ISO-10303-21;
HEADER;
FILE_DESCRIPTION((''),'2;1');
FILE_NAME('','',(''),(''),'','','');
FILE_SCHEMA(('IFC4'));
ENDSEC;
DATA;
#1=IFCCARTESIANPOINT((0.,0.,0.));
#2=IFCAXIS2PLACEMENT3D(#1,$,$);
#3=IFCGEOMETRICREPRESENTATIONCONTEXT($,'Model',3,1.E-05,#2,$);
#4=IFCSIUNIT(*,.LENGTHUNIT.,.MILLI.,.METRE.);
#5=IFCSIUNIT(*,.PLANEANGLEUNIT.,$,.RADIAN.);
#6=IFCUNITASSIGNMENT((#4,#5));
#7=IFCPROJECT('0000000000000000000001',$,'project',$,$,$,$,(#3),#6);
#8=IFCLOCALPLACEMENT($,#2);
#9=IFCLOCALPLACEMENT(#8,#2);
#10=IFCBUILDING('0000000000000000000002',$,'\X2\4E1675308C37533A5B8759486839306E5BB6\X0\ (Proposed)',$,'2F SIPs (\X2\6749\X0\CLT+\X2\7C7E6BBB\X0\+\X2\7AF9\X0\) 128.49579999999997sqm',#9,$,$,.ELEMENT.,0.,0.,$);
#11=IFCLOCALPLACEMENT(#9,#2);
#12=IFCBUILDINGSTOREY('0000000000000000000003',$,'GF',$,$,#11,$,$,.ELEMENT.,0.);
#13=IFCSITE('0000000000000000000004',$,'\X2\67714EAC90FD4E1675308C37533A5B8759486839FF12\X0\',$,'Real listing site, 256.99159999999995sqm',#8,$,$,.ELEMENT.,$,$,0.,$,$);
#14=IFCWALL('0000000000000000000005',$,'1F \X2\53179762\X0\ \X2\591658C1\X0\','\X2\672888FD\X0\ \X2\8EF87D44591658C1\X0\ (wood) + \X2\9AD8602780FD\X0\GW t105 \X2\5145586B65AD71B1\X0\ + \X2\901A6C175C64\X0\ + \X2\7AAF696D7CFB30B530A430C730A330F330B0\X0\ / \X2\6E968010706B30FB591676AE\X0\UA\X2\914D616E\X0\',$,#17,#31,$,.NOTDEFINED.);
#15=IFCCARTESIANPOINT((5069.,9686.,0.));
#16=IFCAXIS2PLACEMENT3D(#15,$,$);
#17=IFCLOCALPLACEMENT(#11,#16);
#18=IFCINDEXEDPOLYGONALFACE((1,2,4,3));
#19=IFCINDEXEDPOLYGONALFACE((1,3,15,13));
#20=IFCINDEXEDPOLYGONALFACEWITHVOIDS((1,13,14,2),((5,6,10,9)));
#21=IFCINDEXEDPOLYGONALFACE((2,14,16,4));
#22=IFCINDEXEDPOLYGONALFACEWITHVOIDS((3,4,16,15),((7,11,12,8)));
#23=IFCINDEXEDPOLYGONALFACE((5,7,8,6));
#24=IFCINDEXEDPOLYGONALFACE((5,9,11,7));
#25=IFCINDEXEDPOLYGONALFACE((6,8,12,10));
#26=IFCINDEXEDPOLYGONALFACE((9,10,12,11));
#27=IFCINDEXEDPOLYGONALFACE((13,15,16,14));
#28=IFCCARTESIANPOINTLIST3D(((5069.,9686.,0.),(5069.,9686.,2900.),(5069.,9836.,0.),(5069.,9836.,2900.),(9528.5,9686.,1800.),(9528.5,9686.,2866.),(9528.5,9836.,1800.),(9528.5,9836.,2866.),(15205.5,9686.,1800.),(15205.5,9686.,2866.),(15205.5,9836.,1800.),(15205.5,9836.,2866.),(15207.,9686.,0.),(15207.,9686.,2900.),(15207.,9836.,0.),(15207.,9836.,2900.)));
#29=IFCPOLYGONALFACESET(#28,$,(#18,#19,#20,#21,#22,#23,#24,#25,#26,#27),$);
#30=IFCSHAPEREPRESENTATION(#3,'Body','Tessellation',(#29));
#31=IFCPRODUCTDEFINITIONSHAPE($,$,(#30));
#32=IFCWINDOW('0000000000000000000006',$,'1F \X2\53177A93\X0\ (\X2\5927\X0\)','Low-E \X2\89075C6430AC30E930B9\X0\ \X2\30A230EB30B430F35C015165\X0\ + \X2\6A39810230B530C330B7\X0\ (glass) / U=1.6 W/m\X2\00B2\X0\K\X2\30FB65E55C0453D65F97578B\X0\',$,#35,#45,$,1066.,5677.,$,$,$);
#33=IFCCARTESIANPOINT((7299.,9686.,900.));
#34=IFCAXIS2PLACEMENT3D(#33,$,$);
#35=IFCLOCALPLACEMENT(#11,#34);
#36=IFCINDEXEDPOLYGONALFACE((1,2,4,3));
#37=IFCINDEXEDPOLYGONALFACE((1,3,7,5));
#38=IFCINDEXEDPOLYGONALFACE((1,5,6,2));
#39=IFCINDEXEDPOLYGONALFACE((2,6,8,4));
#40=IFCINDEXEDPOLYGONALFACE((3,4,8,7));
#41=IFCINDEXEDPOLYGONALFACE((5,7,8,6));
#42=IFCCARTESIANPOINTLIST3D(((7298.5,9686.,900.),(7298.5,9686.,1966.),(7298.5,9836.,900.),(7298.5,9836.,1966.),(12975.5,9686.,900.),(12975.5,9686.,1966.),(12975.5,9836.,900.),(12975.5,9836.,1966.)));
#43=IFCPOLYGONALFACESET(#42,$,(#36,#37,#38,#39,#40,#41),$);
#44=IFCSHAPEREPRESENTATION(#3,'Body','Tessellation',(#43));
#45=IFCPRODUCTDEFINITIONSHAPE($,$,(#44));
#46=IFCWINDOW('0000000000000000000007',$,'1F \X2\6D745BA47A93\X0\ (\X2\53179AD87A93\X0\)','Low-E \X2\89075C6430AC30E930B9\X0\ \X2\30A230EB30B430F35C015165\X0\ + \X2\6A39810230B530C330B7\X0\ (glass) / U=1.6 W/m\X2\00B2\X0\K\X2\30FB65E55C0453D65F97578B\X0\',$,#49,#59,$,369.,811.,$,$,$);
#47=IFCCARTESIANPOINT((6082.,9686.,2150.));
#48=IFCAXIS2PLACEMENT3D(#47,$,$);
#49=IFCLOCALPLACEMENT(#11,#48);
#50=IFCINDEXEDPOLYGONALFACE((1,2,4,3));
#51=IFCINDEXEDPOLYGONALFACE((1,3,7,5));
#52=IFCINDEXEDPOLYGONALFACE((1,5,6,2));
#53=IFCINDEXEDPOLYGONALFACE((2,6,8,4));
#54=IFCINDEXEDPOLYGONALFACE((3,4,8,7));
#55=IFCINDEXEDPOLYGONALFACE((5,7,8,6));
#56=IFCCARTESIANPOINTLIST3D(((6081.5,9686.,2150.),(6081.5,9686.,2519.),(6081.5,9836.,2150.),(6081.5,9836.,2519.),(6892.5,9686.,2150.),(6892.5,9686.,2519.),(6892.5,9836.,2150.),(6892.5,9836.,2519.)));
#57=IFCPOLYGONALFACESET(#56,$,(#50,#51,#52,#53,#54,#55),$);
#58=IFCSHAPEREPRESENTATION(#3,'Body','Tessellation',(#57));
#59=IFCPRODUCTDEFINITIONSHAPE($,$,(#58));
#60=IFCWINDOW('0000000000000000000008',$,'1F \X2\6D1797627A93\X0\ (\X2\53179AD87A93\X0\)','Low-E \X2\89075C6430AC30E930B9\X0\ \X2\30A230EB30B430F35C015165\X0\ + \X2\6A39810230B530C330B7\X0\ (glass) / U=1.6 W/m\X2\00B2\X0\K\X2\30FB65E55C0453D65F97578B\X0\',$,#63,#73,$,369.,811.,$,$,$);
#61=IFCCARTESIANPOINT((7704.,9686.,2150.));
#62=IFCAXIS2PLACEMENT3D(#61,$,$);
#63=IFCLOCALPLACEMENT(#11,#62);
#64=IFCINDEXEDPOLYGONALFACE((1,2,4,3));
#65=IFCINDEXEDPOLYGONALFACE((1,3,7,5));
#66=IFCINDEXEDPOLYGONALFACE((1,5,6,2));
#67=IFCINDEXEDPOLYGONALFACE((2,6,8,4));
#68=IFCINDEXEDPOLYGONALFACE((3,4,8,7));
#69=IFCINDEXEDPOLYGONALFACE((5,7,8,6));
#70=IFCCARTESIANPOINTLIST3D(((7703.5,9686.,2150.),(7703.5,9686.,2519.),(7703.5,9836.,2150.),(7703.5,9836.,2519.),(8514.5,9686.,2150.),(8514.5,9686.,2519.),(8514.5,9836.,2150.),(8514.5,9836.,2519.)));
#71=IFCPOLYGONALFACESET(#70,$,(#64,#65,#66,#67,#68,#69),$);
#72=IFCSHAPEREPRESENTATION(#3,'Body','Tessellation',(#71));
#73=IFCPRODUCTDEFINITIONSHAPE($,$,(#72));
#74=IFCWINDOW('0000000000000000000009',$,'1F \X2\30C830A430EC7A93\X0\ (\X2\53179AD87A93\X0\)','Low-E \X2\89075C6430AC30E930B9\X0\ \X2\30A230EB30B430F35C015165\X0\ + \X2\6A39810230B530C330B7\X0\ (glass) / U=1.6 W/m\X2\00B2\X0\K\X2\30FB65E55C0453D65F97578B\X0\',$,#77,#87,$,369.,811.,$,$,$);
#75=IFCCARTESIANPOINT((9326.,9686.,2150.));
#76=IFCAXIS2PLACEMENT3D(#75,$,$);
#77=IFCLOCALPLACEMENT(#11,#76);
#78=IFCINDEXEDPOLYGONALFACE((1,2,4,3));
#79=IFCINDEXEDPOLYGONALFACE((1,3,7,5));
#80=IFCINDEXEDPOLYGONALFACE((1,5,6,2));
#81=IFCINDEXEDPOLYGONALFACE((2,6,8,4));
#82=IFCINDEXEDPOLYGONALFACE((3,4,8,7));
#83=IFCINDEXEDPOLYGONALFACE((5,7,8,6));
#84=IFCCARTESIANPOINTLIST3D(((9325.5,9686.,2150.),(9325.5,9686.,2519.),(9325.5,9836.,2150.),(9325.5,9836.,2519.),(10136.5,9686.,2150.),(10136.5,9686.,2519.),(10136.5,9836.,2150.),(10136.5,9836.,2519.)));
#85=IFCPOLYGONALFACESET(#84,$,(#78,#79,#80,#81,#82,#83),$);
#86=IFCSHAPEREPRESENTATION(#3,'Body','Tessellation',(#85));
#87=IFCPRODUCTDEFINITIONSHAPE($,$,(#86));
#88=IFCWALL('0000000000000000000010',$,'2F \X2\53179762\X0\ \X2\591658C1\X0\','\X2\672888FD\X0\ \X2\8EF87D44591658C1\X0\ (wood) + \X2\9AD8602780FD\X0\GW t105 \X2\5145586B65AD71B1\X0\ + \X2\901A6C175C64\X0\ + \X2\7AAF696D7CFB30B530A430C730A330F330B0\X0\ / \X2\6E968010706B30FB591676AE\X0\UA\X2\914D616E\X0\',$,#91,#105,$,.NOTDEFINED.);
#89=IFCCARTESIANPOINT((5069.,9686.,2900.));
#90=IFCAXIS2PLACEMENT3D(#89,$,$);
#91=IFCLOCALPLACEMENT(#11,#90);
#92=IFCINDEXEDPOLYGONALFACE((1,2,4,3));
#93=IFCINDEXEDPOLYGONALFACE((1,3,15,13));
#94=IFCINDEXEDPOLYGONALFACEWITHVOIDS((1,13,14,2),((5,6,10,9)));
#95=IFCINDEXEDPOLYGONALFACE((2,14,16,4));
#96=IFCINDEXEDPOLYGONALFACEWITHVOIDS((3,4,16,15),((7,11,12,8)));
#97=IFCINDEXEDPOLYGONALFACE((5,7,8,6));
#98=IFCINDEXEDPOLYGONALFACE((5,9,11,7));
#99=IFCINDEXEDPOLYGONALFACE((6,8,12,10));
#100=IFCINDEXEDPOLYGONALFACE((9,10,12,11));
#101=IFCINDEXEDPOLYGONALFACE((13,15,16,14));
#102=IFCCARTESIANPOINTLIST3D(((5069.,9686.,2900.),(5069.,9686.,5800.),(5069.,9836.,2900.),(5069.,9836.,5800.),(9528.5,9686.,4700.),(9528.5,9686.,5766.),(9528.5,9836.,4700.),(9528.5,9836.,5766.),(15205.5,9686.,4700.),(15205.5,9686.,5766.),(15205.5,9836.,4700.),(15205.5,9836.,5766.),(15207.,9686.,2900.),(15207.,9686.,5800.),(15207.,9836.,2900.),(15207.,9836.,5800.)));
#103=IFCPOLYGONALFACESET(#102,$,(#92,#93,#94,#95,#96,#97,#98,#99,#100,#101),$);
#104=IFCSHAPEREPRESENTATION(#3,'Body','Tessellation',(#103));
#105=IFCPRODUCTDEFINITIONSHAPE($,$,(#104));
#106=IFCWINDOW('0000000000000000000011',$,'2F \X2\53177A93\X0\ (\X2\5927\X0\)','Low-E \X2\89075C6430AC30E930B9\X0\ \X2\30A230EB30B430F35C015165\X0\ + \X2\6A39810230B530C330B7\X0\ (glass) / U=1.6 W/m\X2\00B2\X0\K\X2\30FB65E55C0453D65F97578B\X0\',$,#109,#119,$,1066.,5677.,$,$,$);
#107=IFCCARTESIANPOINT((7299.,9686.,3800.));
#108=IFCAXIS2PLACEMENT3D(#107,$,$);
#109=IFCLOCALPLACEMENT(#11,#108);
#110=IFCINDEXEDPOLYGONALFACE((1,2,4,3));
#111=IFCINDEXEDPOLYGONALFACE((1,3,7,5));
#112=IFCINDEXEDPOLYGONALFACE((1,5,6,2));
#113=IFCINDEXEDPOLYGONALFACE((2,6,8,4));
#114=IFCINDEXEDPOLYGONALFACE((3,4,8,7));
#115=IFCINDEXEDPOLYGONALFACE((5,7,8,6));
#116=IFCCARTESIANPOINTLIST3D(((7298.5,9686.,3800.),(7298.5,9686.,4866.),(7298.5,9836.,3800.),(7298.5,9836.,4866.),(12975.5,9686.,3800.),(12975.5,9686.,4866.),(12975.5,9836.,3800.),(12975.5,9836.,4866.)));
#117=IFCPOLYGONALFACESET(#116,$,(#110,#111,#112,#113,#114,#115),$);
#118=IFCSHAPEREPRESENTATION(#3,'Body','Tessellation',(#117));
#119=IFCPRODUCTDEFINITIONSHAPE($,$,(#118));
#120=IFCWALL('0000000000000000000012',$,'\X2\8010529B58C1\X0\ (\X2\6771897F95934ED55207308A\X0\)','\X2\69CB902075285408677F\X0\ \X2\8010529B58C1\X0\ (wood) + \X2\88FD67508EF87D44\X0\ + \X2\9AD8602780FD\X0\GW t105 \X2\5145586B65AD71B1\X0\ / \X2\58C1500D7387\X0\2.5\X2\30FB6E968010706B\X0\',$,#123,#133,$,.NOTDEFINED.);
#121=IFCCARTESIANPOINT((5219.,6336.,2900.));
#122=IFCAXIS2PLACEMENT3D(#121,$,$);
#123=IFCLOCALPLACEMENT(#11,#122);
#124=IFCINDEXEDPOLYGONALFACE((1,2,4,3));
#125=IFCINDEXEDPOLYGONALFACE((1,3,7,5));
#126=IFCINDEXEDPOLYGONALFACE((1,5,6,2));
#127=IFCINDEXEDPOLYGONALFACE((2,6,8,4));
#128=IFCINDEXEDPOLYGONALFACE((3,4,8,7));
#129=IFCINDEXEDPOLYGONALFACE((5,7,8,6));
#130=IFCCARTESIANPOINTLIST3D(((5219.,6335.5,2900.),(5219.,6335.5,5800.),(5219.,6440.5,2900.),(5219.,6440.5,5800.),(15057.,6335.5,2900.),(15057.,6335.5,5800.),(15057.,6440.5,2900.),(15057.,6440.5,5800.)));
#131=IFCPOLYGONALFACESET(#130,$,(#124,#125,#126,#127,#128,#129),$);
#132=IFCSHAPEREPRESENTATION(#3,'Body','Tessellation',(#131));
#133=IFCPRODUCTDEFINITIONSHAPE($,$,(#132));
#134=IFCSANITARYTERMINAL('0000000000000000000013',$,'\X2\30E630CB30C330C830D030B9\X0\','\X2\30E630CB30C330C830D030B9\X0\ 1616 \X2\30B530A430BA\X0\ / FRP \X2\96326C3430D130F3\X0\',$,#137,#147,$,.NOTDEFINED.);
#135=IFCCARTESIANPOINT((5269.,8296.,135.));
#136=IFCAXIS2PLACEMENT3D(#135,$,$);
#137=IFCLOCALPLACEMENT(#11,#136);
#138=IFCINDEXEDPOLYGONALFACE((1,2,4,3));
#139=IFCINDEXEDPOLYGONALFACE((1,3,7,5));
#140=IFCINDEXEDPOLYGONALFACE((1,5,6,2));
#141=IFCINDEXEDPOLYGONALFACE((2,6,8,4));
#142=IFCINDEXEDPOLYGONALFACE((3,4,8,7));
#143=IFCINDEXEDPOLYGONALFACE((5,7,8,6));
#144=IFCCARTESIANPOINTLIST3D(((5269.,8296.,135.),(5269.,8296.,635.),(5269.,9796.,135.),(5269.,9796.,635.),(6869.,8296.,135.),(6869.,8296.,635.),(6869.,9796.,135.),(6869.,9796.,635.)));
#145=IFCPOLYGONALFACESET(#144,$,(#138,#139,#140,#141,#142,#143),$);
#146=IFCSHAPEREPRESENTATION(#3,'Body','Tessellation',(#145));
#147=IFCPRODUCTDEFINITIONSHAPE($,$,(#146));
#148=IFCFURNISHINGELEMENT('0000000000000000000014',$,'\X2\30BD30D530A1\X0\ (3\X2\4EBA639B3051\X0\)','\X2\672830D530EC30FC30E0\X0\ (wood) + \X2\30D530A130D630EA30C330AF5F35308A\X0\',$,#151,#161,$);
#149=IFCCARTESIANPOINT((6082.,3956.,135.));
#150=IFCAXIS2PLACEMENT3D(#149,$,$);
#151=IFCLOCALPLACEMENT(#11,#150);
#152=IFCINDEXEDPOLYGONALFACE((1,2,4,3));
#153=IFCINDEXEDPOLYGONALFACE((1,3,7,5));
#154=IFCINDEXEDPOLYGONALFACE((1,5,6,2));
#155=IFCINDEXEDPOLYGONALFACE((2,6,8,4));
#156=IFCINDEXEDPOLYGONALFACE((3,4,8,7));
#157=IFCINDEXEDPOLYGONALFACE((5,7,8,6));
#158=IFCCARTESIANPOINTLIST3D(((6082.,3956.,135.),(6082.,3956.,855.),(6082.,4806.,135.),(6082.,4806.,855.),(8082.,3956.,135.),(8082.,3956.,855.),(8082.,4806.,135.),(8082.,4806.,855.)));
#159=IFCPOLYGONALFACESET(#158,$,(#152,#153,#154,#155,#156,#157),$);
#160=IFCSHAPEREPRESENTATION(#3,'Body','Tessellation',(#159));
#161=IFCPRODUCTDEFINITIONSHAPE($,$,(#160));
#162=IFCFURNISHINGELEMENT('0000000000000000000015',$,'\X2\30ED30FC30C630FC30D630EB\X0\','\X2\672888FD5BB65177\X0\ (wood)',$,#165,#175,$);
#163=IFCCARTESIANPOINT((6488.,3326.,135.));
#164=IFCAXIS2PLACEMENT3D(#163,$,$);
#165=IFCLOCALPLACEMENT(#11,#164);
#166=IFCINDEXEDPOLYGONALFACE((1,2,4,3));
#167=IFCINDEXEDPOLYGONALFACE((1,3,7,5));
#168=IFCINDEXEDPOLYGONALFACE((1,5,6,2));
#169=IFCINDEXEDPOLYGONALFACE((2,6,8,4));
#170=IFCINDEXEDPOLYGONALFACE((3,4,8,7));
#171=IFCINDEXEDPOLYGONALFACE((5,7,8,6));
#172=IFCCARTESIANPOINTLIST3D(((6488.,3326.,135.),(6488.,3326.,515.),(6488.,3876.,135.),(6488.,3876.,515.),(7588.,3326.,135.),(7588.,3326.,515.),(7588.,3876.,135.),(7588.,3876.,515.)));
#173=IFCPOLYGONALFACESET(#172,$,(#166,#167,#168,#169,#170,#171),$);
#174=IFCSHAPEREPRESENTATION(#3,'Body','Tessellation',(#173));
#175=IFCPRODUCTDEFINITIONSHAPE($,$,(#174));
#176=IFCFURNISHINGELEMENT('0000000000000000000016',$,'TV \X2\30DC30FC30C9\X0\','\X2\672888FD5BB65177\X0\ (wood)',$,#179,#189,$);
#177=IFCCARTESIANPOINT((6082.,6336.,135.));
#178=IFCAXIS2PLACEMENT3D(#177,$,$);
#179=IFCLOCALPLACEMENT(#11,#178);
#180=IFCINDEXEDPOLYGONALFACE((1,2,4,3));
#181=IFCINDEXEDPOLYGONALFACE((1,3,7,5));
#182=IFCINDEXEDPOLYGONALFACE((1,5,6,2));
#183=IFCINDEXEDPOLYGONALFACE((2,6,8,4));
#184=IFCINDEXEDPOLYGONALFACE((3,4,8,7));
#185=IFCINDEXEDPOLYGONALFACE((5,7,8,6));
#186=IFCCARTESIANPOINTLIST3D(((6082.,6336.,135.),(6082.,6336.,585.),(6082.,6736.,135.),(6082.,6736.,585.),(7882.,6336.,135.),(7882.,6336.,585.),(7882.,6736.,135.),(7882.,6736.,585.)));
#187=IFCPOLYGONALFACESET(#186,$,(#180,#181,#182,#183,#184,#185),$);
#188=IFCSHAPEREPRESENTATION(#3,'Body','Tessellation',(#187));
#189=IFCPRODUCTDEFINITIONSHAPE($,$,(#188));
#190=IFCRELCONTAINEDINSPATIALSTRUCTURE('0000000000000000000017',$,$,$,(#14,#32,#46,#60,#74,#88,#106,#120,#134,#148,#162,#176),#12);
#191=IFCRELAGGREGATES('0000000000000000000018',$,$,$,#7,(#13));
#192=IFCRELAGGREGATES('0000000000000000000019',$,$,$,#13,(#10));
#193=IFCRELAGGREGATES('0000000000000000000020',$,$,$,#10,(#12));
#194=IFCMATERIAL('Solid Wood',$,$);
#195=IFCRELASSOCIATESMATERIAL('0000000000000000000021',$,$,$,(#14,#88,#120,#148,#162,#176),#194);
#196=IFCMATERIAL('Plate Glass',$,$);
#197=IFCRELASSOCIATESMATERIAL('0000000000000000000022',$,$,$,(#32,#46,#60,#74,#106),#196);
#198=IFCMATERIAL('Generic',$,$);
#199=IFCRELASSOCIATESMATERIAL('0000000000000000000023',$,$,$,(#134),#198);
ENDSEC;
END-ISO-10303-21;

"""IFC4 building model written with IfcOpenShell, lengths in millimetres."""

from ifc_helpers import new_model, si_unit, frame, frame_2d, origin, place, context, project, spatial, rectangle, extrude, material, element, fill, save


model = new_model("IFC4")

# Units and contexts
model_context = context("Model", 3, precision=1e-05, world=origin())
ifc_project = project(units=[si_unit("LENGTHUNIT", "METRE", prefix="MILLI"), si_unit("PLANEANGLEUNIT", "RADIAN")], contexts=[model_context])

# Site, building, storey
site_placement = place(None, origin())
site = spatial("IfcSite", under=ifc_project, at=site_placement, Name="東京都世田谷区宇奈根２", ObjectType="Real listing site, 256.99159999999995sqm", CompositionType="ELEMENT", RefElevation=0.0)
building_placement = place(site_placement, origin())
building = spatial("IfcBuilding", under=site, at=building_placement, Name="世田谷区宇奈根の家 (Proposed)", ObjectType="2F SIPs (杉CLT+籾殻+竹) 128.49579999999997sqm", CompositionType="ELEMENT", ElevationOfRefHeight=0.0, ElevationOfTerrain=0.0)
storey_placement = place(building_placement, origin())
storey = spatial("IfcBuildingStorey", under=building, at=storey_placement, Name="GF", CompositionType="ELEMENT", Elevation=0.0)

# Wall, openings, windows
ifc_material_1 = material(Name="Solid Wood")
wall_1_placement = place(storey_placement, frame((5069.0, 9686.0, 0.0)))
wall_1 = element("IfcWall", 1, at=wall_1_placement, inside=storey, material=ifc_material_1, Name="1F 北面 外壁", Description="木製 軸組外壁 (wood) + 高性能GW t105 充填断熱 + 通気層 + 窯業系サイディング / 準耐火・外皮UA配慮", PredefinedType="NOTDEFINED", context=model_context, shape_type="SweptSolid", body=[
    extrude(rectangle(XDim=10138.0, YDim=150.0, at=frame_2d((5069.0, 75.0))), frame((5069.0, 9686.0, 0.0)), (0.0, 0.0, 1.0), 2900.0),
])
opening_1_placement = place(storey_placement, frame((7299.0, 9686.0, 900.0)))
opening_1 = element("IfcOpeningElement", 2, at=opening_1_placement, cuts=wall_1, PredefinedType="NOTDEFINED", context=model_context, shape_type="SweptSolid", body=[
    extrude(rectangle(XDim=5677.0, YDim=150.0, at=frame_2d((2838.0, 75.0))), frame((7299.0, 9686.0, 900.0)), (0.0, 0.0, 1.0), 1066.0),
])
opening_2_placement = place(storey_placement, frame((6082.0, 9686.0, 2150.0)))
opening_2 = element("IfcOpeningElement", 3, at=opening_2_placement, cuts=wall_1, PredefinedType="NOTDEFINED", context=model_context, shape_type="SweptSolid", body=[
    extrude(rectangle(XDim=811.0, YDim=150.0, at=frame_2d((405.0, 75.0))), frame((6082.0, 9686.0, 2150.0)), (0.0, 0.0, 1.0), 369.0),
])
opening_3_placement = place(storey_placement, frame((7704.0, 9686.0, 2150.0)))
opening_3 = element("IfcOpeningElement", 4, at=opening_3_placement, cuts=wall_1, PredefinedType="NOTDEFINED", context=model_context, shape_type="SweptSolid", body=[
    extrude(rectangle(XDim=811.0, YDim=150.0, at=frame_2d((405.0, 75.0))), frame((7704.0, 9686.0, 2150.0)), (0.0, 0.0, 1.0), 369.0),
])
opening_4_placement = place(storey_placement, frame((9326.0, 9686.0, 2150.0)))
opening_4 = element("IfcOpeningElement", 5, at=opening_4_placement, cuts=wall_1, PredefinedType="NOTDEFINED", context=model_context, shape_type="SweptSolid", body=[
    extrude(rectangle(XDim=811.0, YDim=150.0, at=frame_2d((405.0, 75.0))), frame((9326.0, 9686.0, 2150.0)), (0.0, 0.0, 1.0), 369.0),
])
ifc_material_2 = material(Name="Plate Glass")
window_1_placement = place(storey_placement, frame((7299.0, 9686.0, 900.0)))
window_1 = element("IfcWindow", 6, at=window_1_placement, inside=storey, material=ifc_material_2, Name="1F 北窓 (大)", Description="Low-E 複層ガラス アルゴン封入 + 樹脂サッシ (glass) / U=1.6 W/m²K・日射取得型", OverallHeight=1066.0, OverallWidth=5677.0, context=model_context, shape_type="SweptSolid", body=[
    extrude(rectangle(XDim=5677.0, YDim=150.0, at=frame_2d((2838.0, 75.0))), frame((7299.0, 9686.0, 900.0)), (0.0, 0.0, 1.0), 1066.0),
])
fill(opening_1, window_1)
window_2_placement = place(storey_placement, frame((6082.0, 9686.0, 2150.0)))
window_2 = element("IfcWindow", 7, at=window_2_placement, inside=storey, material=ifc_material_2, Name="1F 浴室窓 (北高窓)", Description="Low-E 複層ガラス アルゴン封入 + 樹脂サッシ (glass) / U=1.6 W/m²K・日射取得型", OverallHeight=369.0, OverallWidth=811.0, context=model_context, shape_type="SweptSolid", body=[
    extrude(rectangle(XDim=811.0, YDim=150.0, at=frame_2d((405.0, 75.0))), frame((6082.0, 9686.0, 2150.0)), (0.0, 0.0, 1.0), 369.0),
])
fill(opening_2, window_2)
window_3_placement = place(storey_placement, frame((7704.0, 9686.0, 2150.0)))
window_3 = element("IfcWindow", 8, at=window_3_placement, inside=storey, material=ifc_material_2, Name="1F 洗面窓 (北高窓)", Description="Low-E 複層ガラス アルゴン封入 + 樹脂サッシ (glass) / U=1.6 W/m²K・日射取得型", OverallHeight=369.0, OverallWidth=811.0, context=model_context, shape_type="SweptSolid", body=[
    extrude(rectangle(XDim=811.0, YDim=150.0, at=frame_2d((405.0, 75.0))), frame((7704.0, 9686.0, 2150.0)), (0.0, 0.0, 1.0), 369.0),
])
fill(opening_3, window_3)
window_4_placement = place(storey_placement, frame((9326.0, 9686.0, 2150.0)))
window_4 = element("IfcWindow", 9, at=window_4_placement, inside=storey, material=ifc_material_2, Name="1F トイレ窓 (北高窓)", Description="Low-E 複層ガラス アルゴン封入 + 樹脂サッシ (glass) / U=1.6 W/m²K・日射取得型", OverallHeight=369.0, OverallWidth=811.0, context=model_context, shape_type="SweptSolid", body=[
    extrude(rectangle(XDim=811.0, YDim=150.0, at=frame_2d((405.0, 75.0))), frame((9326.0, 9686.0, 2150.0)), (0.0, 0.0, 1.0), 369.0),
])
fill(opening_4, window_4)

# Wall, opening, window
wall_2_placement = place(storey_placement, frame((5069.0, 9686.0, 2900.0)))
wall_2 = element("IfcWall", 10, at=wall_2_placement, inside=storey, material=ifc_material_1, Name="2F 北面 外壁", Description="木製 軸組外壁 (wood) + 高性能GW t105 充填断熱 + 通気層 + 窯業系サイディング / 準耐火・外皮UA配慮", PredefinedType="NOTDEFINED", context=model_context, shape_type="SweptSolid", body=[
    extrude(rectangle(XDim=10138.0, YDim=150.0, at=frame_2d((5069.0, 75.0))), frame((5069.0, 9686.0, 2900.0)), (0.0, 0.0, 1.0), 2900.0),
])
opening_5_placement = place(storey_placement, frame((7299.0, 9686.0, 3800.0)))
opening_5 = element("IfcOpeningElement", 11, at=opening_5_placement, cuts=wall_2, PredefinedType="NOTDEFINED", context=model_context, shape_type="SweptSolid", body=[
    extrude(rectangle(XDim=5677.0, YDim=150.0, at=frame_2d((2838.0, 75.0))), frame((7299.0, 9686.0, 3800.0)), (0.0, 0.0, 1.0), 1066.0),
])
window_5_placement = place(storey_placement, frame((7299.0, 9686.0, 3800.0)))
window_5 = element("IfcWindow", 12, at=window_5_placement, inside=storey, material=ifc_material_2, Name="2F 北窓 (大)", Description="Low-E 複層ガラス アルゴン封入 + 樹脂サッシ (glass) / U=1.6 W/m²K・日射取得型", OverallHeight=1066.0, OverallWidth=5677.0, context=model_context, shape_type="SweptSolid", body=[
    extrude(rectangle(XDim=5677.0, YDim=150.0, at=frame_2d((2838.0, 75.0))), frame((7299.0, 9686.0, 3800.0)), (0.0, 0.0, 1.0), 1066.0),
])
fill(opening_5, window_5)

# Wall
wall_3_placement = place(storey_placement, frame((5219.0, 6336.0, 2900.0)))
element("IfcWall", 13, at=wall_3_placement, inside=storey, material=ifc_material_1, Name="耐力壁 (東西間仕切り)", Description="構造用合板 耐力壁 (wood) + 製材軸組 + 高性能GW t105 充填断熱 / 壁倍率2.5・準耐火", PredefinedType="NOTDEFINED", context=model_context, shape_type="SweptSolid", body=[
    extrude(rectangle(XDim=9838.0, YDim=105.0, at=frame_2d((4919.0, 52.0))), frame((5219.0, 6336.0, 2900.0)), (0.0, 0.0, 1.0), 2900.0),
])

# Sanitary terminal
ifc_material_3 = material(Name="Generic")
sanitary_terminal_placement = place(storey_placement, frame((5269.0, 8296.0, 135.0)))
element("IfcSanitaryTerminal", 14, at=sanitary_terminal_placement, inside=storey, material=ifc_material_3, Name="ユニットバス", Description="ユニットバス 1616 サイズ / FRP 防水パン", PredefinedType="NOTDEFINED", context=model_context, shape_type="SweptSolid", body=[
    extrude(rectangle(XDim=1600.0, YDim=1500.0, at=frame_2d((800.0, 750.0))), frame((5269.0, 8296.0, 135.0)), (0.0, 0.0, 1.0), 500.0),
])

# Furnishing elements
furnishing_1_placement = place(storey_placement, frame((6082.0, 3956.0, 135.0)))
element("IfcFurnishingElement", 15, at=furnishing_1_placement, inside=storey, material=ifc_material_1, Name="ソファ (3人掛け)", Description="木フレーム (wood) + ファブリック張り", context=model_context, shape_type="SweptSolid", body=[
    extrude(rectangle(XDim=2000.0, YDim=850.0, at=frame_2d((1000.0, 425.0))), frame((6082.0, 3956.0, 135.0)), (0.0, 0.0, 1.0), 720.0),
])
furnishing_2_placement = place(storey_placement, frame((6488.0, 3326.0, 135.0)))
element("IfcFurnishingElement", 16, at=furnishing_2_placement, inside=storey, material=ifc_material_1, Name="ローテーブル", Description="木製家具 (wood)", context=model_context, shape_type="SweptSolid", body=[
    extrude(rectangle(XDim=1100.0, YDim=550.0, at=frame_2d((550.0, 275.0))), frame((6488.0, 3326.0, 135.0)), (0.0, 0.0, 1.0), 380.0),
])
furnishing_3_placement = place(storey_placement, frame((6082.0, 6336.0, 135.0)))
element("IfcFurnishingElement", 17, at=furnishing_3_placement, inside=storey, material=ifc_material_1, Name="TV ボード", Description="木製家具 (wood)", context=model_context, shape_type="SweptSolid", body=[
    extrude(rectangle(XDim=1800.0, YDim=400.0, at=frame_2d((900.0, 200.0))), frame((6082.0, 6336.0, 135.0)), (0.0, 0.0, 1.0), 450.0),
])

save(model, "model.ifc")
